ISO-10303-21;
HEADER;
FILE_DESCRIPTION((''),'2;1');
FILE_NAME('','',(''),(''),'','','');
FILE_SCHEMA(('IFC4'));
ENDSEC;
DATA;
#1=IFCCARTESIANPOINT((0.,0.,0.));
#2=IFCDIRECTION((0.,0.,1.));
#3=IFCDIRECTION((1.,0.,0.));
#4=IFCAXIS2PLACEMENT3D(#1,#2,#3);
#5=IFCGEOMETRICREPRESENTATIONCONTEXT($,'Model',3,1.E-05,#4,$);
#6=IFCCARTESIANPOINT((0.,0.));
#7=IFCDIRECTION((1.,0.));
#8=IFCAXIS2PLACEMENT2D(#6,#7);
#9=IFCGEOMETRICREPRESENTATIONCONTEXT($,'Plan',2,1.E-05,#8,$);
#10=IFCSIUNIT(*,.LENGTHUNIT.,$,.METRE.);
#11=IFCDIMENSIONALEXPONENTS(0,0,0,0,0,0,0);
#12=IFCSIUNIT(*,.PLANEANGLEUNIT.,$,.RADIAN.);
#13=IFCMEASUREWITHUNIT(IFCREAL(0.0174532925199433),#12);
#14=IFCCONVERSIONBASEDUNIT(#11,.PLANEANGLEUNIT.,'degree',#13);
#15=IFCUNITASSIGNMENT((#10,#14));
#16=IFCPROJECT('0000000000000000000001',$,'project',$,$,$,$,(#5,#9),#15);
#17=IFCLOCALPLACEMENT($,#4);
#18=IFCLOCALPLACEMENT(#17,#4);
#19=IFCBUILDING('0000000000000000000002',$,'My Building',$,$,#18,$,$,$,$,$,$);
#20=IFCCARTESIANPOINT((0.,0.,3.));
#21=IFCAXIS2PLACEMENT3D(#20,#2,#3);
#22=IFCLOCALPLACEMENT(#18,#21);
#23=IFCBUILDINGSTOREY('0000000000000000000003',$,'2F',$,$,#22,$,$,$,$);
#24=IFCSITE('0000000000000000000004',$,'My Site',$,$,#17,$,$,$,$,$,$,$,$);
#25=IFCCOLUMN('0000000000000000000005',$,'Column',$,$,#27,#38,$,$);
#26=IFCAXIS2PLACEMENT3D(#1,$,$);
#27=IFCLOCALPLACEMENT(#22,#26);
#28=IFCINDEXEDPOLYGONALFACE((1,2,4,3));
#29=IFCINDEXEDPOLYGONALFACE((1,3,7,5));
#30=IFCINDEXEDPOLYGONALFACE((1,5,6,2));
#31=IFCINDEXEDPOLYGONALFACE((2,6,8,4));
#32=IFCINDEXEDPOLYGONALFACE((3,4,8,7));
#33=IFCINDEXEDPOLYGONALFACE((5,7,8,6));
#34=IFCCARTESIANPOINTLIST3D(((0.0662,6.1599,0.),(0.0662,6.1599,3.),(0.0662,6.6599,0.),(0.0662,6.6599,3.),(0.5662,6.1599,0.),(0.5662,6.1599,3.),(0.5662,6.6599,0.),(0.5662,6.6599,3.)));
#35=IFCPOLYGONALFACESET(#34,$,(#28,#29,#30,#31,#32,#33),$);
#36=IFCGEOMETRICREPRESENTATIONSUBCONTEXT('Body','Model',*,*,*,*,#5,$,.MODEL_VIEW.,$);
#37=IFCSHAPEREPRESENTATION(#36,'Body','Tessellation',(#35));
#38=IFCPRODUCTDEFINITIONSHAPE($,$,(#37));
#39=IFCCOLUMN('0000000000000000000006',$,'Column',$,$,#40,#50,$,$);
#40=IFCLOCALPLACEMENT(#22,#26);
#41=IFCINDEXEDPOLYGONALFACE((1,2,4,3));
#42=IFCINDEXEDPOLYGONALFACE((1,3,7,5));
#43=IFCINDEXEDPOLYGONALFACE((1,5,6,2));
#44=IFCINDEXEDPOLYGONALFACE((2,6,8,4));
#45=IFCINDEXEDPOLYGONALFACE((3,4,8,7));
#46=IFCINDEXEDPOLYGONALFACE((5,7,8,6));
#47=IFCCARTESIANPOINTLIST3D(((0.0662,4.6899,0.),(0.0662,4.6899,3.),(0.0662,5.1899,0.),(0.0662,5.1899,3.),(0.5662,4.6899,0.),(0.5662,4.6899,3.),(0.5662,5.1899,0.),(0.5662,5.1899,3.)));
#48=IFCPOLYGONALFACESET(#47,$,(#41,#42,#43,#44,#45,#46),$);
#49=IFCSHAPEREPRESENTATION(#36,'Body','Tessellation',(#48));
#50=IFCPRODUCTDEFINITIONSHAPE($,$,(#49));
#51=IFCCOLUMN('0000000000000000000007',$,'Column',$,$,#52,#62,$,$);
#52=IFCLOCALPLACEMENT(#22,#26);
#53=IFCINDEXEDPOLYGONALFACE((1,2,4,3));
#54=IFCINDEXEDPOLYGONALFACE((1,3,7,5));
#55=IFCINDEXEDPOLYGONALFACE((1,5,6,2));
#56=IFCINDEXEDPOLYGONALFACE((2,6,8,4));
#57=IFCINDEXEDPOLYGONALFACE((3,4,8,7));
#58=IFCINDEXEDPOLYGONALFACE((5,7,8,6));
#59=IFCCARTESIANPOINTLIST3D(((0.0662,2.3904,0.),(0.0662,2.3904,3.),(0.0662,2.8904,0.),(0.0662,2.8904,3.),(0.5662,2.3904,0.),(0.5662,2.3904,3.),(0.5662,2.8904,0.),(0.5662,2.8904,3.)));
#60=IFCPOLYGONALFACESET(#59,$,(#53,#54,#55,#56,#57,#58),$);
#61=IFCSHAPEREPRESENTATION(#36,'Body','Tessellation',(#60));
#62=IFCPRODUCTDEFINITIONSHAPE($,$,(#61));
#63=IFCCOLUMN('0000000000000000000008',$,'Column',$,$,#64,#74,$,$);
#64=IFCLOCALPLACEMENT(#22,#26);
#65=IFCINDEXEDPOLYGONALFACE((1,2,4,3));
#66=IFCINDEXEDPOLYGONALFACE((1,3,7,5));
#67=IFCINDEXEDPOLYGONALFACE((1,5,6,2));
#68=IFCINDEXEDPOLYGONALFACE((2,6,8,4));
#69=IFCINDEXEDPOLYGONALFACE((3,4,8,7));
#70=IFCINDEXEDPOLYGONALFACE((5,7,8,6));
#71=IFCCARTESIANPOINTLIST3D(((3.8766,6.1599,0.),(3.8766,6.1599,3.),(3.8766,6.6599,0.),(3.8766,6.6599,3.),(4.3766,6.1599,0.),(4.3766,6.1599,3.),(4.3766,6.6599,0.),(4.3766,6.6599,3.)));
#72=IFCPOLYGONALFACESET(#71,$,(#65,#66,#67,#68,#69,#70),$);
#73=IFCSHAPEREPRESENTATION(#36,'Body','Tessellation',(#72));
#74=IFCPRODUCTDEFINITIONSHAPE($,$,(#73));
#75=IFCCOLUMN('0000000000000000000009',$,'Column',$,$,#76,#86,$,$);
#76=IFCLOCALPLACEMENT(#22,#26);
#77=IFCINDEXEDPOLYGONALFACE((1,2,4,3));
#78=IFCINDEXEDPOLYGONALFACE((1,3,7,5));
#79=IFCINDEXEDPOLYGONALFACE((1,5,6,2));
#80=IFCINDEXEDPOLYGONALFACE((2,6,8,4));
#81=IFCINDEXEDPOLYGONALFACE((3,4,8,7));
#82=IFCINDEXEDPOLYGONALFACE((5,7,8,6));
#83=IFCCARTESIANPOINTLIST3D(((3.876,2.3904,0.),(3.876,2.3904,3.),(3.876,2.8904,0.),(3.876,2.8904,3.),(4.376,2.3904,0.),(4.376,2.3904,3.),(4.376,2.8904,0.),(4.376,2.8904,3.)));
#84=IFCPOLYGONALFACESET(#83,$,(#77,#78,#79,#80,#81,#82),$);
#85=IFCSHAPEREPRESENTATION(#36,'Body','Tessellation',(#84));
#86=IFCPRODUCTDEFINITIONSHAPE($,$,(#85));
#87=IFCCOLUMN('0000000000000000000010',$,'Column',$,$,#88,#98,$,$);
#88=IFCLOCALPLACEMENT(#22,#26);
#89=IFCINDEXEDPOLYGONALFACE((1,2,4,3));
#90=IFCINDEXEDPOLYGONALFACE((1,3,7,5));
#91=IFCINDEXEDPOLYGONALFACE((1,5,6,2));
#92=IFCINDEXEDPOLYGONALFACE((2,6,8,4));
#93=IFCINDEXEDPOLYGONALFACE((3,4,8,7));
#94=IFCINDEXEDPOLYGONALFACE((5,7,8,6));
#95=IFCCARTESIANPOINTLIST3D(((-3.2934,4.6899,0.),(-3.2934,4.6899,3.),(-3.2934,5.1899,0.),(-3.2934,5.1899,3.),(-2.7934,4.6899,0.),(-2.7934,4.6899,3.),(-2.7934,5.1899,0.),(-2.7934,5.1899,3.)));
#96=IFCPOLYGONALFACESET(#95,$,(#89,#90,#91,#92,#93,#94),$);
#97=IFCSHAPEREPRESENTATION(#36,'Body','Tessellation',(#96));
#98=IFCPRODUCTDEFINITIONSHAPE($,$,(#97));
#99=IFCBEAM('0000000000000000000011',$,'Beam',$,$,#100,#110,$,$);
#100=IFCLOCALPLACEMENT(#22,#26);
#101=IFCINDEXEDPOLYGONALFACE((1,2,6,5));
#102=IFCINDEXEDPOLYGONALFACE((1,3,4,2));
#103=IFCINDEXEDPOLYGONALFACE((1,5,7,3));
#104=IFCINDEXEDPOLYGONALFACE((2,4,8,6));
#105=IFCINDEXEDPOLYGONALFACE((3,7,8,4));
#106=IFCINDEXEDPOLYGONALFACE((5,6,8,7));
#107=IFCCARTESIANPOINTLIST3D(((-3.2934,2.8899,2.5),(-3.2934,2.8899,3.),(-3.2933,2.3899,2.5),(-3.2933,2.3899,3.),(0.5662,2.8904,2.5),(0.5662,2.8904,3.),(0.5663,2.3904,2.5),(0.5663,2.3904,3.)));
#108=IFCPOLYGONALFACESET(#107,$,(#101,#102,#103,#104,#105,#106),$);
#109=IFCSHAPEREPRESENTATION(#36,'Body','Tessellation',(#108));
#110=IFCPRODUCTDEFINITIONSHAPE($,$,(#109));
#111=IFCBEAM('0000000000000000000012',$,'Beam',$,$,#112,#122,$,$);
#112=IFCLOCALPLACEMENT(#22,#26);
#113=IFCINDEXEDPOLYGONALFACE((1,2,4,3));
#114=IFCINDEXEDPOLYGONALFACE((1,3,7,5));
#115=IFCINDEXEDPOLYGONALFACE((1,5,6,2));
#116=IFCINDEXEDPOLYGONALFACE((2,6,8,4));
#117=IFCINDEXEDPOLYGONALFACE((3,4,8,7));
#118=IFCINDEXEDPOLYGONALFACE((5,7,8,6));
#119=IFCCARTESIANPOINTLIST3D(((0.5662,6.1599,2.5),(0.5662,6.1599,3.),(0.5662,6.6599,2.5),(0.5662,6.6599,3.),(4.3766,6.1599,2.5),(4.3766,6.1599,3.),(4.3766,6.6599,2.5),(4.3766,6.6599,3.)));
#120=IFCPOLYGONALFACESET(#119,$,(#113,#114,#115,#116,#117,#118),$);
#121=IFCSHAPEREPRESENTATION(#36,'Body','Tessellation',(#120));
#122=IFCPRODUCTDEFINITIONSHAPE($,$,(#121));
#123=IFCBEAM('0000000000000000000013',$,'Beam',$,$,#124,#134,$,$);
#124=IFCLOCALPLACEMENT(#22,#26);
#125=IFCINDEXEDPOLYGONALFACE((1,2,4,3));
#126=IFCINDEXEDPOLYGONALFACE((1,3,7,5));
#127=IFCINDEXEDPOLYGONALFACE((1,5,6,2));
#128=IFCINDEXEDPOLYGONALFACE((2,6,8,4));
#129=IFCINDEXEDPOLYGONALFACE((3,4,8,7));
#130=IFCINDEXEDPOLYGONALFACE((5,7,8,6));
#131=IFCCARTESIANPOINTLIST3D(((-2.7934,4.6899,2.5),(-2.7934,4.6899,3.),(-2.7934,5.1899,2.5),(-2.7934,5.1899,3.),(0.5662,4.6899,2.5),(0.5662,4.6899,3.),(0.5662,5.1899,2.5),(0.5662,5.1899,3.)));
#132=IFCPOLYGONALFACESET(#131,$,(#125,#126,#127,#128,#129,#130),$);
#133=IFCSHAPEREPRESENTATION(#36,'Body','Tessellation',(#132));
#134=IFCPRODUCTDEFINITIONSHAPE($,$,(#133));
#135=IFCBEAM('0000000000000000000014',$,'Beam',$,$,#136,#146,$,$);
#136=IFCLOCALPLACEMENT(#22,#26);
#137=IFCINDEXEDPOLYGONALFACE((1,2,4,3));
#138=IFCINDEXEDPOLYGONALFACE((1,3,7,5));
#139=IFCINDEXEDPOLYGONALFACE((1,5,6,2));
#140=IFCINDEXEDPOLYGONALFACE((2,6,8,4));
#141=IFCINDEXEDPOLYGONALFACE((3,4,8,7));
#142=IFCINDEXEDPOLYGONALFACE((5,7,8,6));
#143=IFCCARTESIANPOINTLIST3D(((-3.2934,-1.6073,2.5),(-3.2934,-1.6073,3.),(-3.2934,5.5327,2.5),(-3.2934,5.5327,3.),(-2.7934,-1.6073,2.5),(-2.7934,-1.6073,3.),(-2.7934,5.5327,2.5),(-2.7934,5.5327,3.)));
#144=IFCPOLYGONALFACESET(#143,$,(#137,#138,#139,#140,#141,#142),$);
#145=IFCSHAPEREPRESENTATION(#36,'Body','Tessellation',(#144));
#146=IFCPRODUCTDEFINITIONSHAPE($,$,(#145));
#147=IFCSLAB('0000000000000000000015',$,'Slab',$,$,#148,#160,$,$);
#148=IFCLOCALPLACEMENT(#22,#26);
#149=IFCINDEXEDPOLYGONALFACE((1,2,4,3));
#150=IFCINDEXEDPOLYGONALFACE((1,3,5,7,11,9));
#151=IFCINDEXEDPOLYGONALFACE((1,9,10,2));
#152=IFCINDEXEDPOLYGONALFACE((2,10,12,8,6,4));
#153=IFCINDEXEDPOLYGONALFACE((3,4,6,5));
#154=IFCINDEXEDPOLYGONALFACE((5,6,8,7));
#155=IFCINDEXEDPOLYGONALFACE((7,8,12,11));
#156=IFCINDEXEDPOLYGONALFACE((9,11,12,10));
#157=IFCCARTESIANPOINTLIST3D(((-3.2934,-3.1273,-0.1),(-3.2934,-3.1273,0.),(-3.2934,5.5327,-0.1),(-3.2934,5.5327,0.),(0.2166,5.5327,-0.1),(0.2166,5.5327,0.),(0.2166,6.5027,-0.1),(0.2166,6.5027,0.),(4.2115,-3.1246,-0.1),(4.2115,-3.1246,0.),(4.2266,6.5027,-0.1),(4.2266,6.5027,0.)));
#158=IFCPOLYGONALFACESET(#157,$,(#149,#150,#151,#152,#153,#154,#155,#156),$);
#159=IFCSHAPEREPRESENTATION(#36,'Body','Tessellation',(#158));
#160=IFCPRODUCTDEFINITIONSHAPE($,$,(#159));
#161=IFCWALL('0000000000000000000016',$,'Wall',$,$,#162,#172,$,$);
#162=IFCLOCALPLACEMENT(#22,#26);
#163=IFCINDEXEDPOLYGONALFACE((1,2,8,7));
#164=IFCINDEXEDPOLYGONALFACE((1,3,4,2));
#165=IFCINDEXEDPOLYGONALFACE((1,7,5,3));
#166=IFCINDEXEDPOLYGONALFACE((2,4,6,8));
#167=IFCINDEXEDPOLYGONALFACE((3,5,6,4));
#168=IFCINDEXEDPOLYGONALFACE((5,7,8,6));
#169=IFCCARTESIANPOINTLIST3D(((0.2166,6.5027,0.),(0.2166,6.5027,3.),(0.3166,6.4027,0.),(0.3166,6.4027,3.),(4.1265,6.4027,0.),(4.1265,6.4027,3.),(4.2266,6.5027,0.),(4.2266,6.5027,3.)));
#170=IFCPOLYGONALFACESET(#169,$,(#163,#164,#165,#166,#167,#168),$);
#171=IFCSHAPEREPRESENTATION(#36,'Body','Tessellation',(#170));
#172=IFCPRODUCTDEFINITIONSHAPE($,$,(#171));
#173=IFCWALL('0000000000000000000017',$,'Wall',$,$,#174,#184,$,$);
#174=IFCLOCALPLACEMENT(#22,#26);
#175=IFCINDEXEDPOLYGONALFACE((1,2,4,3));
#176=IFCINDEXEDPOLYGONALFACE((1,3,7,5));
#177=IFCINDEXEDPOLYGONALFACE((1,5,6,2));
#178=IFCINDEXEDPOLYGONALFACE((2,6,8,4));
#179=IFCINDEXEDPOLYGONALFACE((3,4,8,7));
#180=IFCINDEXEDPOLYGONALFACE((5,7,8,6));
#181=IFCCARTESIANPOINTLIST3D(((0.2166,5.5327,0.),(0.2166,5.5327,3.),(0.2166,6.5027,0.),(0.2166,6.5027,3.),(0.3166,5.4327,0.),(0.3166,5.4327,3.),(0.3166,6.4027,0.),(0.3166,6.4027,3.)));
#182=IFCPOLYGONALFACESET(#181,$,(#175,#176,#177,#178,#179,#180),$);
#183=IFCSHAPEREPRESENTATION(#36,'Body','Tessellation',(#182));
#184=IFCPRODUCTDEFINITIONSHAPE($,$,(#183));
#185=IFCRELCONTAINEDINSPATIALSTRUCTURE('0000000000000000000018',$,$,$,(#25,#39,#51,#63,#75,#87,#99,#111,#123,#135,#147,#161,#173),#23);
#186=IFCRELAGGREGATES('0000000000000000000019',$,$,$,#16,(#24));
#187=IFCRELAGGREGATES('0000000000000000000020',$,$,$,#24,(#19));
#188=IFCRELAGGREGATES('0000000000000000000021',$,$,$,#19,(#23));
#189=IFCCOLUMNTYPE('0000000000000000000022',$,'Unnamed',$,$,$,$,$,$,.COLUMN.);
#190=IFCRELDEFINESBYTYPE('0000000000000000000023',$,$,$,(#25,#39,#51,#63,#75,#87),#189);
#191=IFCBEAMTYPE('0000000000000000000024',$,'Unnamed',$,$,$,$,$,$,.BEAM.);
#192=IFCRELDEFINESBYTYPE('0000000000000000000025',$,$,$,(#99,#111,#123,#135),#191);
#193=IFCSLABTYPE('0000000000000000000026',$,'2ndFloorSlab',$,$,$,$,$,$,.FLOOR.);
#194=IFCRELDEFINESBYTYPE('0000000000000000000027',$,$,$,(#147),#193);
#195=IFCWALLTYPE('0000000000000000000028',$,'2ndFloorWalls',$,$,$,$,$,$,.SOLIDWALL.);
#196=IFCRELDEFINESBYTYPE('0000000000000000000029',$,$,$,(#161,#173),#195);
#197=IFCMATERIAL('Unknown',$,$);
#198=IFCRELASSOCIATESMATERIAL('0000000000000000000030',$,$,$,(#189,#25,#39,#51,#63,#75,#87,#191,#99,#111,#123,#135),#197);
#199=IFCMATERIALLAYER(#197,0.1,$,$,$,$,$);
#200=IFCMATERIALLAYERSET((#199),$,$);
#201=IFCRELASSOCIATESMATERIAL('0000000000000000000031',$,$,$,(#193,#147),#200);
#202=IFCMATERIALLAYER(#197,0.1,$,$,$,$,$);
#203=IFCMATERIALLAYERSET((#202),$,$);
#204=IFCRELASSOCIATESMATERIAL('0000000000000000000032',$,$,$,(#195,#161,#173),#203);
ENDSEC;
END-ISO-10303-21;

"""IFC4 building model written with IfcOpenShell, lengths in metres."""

from ifc_helpers import new_model, entity, si_unit, converted_unit, frame, origin_with_axes, origin_2d_with_axis, place, context, subcontext, project, spatial, line, indexed_curve, rectangle, outline, extrude, material, layer, layer_set, layer_usage, material_profile, profile_set, profile_usage, type_object, element, save


model = new_model("IFC4")

# Units and contexts
model_context = context("Model", 3, precision=1e-05, world=origin_with_axes())
plan_context = context("Plan", 2, precision=1e-05, world=origin_2d_with_axis())
body_context_1 = subcontext(model_context, "Body", "Model", "MODEL_VIEW")
ifc_project = project(units=[si_unit("LENGTHUNIT", "METRE"), converted_unit("PLANEANGLEUNIT", "degree", entity("IfcReal", 0.0174532925199433), si_unit("PLANEANGLEUNIT", "RADIAN"), dimensions=[0, 0, 0, 0, 0, 0, 0])], contexts=[model_context, plan_context])

# Site, building, storey
site_placement = place(None, origin_with_axes())
site = spatial("IfcSite", under=ifc_project, at=site_placement, Name="My Site")
building_placement = place(site_placement, origin_with_axes())
building = spatial("IfcBuilding", under=site, at=building_placement, Name="My Building")
storey_placement = place(building_placement, frame((0.0, 0.0, 3.0), z_axis=(0.0, 0.0, 1.0), x_axis=(1.0, 0.0, 0.0)))
storey = spatial("IfcBuildingStorey", under=building, at=storey_placement, Name="2F")

# Columns
ifc_material = material(Name="Unknown")
ifc_material_profile_1 = material_profile(ifc_material, rectangle(XDim=0.5, YDim=0.5))
ifc_profile_set_1 = profile_set([ifc_material_profile_1])
ifc_profile_usage_1 = profile_usage(ifc_profile_set_1, cardinal=3)
column_type = type_object("IfcColumnType", Name="Unnamed", PredefinedType="COLUMN", material=ifc_profile_set_1)
column_1_placement = place(storey_placement, frame((0.0662, 6.1599, 0.0), z_axis=(0.0, 0.0, 1.0), x_axis=(1.0, 0.0, 0.0)))
element("IfcColumn", 1, at=column_1_placement, inside=storey, type_object=column_type, material=ifc_profile_usage_1, Name="Column", context=body_context_1, shape_type="SweptSolid", body=[
    extrude(rectangle(XDim=0.5, YDim=0.5), frame((0.25, 0.25, 0.0), z_axis=(0.0, 0.0, 1.0), x_axis=(1.0, 0.0, 0.0)), (0.0, 0.0, 1.0), 3.0),
])
ifc_profile_usage_2 = profile_usage(ifc_profile_set_1, cardinal=3)
column_2_placement = place(storey_placement, frame((0.0662, 4.6899, 0.0), z_axis=(0.0, 0.0, 1.0), x_axis=(1.0, 0.0, 0.0)))
element("IfcColumn", 2, at=column_2_placement, inside=storey, type_object=column_type, material=ifc_profile_usage_2, Name="Column", context=body_context_1, shape_type="SweptSolid", body=[
    extrude(rectangle(XDim=0.5, YDim=0.5), frame((0.25, 0.25, 0.0), z_axis=(0.0, 0.0, 1.0), x_axis=(1.0, 0.0, 0.0)), (0.0, 0.0, 1.0), 3.0),
])
ifc_profile_usage_3 = profile_usage(ifc_profile_set_1, cardinal=7)
column_3_placement = place(storey_placement, frame((0.5662, 2.8904, 0.0), z_axis=(0.0, 0.0, 1.0), x_axis=(1.0, 0.0, 0.0)))
element("IfcColumn", 3, at=column_3_placement, inside=storey, type_object=column_type, material=ifc_profile_usage_3, Name="Column", context=body_context_1, shape_type="SweptSolid", body=[
    extrude(rectangle(XDim=0.5, YDim=0.5), frame((-0.25, -0.25, 0.0), z_axis=(0.0, 0.0, 1.0), x_axis=(1.0, 0.0, 0.0)), (0.0, 0.0, 1.0), 3.0),
])
ifc_profile_usage_4 = profile_usage(ifc_profile_set_1, cardinal=7)
column_4_placement = place(storey_placement, frame((4.3766, 6.6599, 0.0), z_axis=(0.0, 0.0, 1.0), x_axis=(1.0, 0.0, 0.0)))
element("IfcColumn", 4, at=column_4_placement, inside=storey, type_object=column_type, material=ifc_profile_usage_4, Name="Column", context=body_context_1, shape_type="SweptSolid", body=[
    extrude(rectangle(XDim=0.5, YDim=0.5), frame((-0.25, -0.25, 0.0), z_axis=(0.0, 0.0, 1.0), x_axis=(1.0, 0.0, 0.0)), (0.0, 0.0, 1.0), 3.0),
])
ifc_profile_usage_5 = profile_usage(ifc_profile_set_1, cardinal=7)
column_5_placement = place(storey_placement, frame((4.376, 2.8904, 0.0), z_axis=(0.0, 0.0, 1.0), x_axis=(1.0, 0.0, 0.0)))
element("IfcColumn", 5, at=column_5_placement, inside=storey, type_object=column_type, material=ifc_profile_usage_5, Name="Column", context=body_context_1, shape_type="SweptSolid", body=[
    extrude(rectangle(XDim=0.5, YDim=0.5), frame((-0.25, -0.25, 0.0), z_axis=(0.0, 0.0, 1.0), x_axis=(1.0, 0.0, 0.0)), (0.0, 0.0, 1.0), 3.0),
])
ifc_profile_usage_6 = profile_usage(ifc_profile_set_1, cardinal=3)
column_6_placement = place(storey_placement, frame((-3.2934, 4.6899, 0.0), z_axis=(0.0, 0.0, 1.0), x_axis=(1.0, 0.0, 0.0)))
element("IfcColumn", 6, at=column_6_placement, inside=storey, type_object=column_type, material=ifc_profile_usage_6, Name="Column", context=body_context_1, shape_type="SweptSolid", body=[
    extrude(rectangle(XDim=0.5, YDim=0.5), frame((0.25, 0.25, 0.0), z_axis=(0.0, 0.0, 1.0), x_axis=(1.0, 0.0, 0.0)), (0.0, 0.0, 1.0), 3.0),
])

# Beams
ifc_material_profile_2 = material_profile(ifc_material, rectangle(XDim=0.5, YDim=0.5))
ifc_profile_set_2 = profile_set([ifc_material_profile_2])
ifc_profile_usage_7 = profile_usage(ifc_profile_set_2, cardinal=9)
beam_type = type_object("IfcBeamType", Name="Unnamed", PredefinedType="BEAM", material=ifc_profile_set_2)
beam_1_placement = place(storey_placement, frame((0.5662, 2.8904, 3.0), z_axis=(-1.0, -0.000134, 0.0), x_axis=(0.000134, -1.0, 0.0)))
element("IfcBeam", 7, at=beam_1_placement, inside=storey, type_object=beam_type, material=ifc_profile_usage_7, Name="Beam", context=body_context_1, shape_type="SweptSolid", body=[
    extrude(rectangle(XDim=0.5, YDim=0.5), frame((0.25, -0.25, 0.0), z_axis=(0.0, 0.0, 1.0), x_axis=(1.0, 0.0, 0.0)), (0.0, 0.0, 1.0), 3.8596),
])
ifc_profile_usage_8 = profile_usage(ifc_profile_set_2, cardinal=9)
beam_2_placement = place(storey_placement, frame((0.5662, 6.1599, 3.0), z_axis=(1.0, 0.0, 0.0), x_axis=(0.0, 1.0, 0.0)))
element("IfcBeam", 8, at=beam_2_placement, inside=storey, type_object=beam_type, material=ifc_profile_usage_8, Name="Beam", context=body_context_1, shape_type="SweptSolid", body=[
    extrude(rectangle(XDim=0.5, YDim=0.5), frame((0.25, -0.25, 0.0), z_axis=(0.0, 0.0, 1.0), x_axis=(1.0, 0.0, 0.0)), (0.0, 0.0, 1.0), 3.8104),
])
ifc_profile_usage_9 = profile_usage(ifc_profile_set_2, cardinal=7)
beam_3_placement = place(storey_placement, frame((-2.7934, 5.1899, 3.0), z_axis=(1.0, 0.0, 0.0), x_axis=(0.0, 1.0, 0.0)))
element("IfcBeam", 9, at=beam_3_placement, inside=storey, type_object=beam_type, material=ifc_profile_usage_9, Name="Beam", context=body_context_1, shape_type="SweptSolid", body=[
    extrude(rectangle(XDim=0.5, YDim=0.5), frame((-0.25, -0.25, 0.0), z_axis=(0.0, 0.0, 1.0), x_axis=(1.0, 0.0, 0.0)), (0.0, 0.0, 1.0), 3.3596),
])
ifc_profile_usage_10 = profile_usage(ifc_profile_set_2, cardinal=9)
beam_4_placement = place(storey_placement, frame((-3.2934, 5.5327, 3.0), z_axis=(0.0, -1.0, 0.0), x_axis=(1.0, 0.0, 0.0)))
element("IfcBeam", 10, at=beam_4_placement, inside=storey, type_object=beam_type, material=ifc_profile_usage_10, Name="Beam", context=body_context_1, shape_type="SweptSolid", body=[
    extrude(rectangle(XDim=0.5, YDim=0.5), frame((0.25, -0.25, 0.0), z_axis=(0.0, 0.0, 1.0), x_axis=(1.0, 0.0, 0.0)), (0.0, 0.0, 1.0), 7.14),
])

# Slab
ifc_layer_1 = layer(ifc_material, 0.1)
ifc_layer_set_1 = layer_set([ifc_layer_1])
ifc_layer_usage_1 = layer_usage(ifc_layer_set_1, "AXIS3", "POSITIVE", -0.1)
slab_type = type_object("IfcSlabType", Name="2ndFloorSlab", PredefinedType="FLOOR", material=ifc_layer_set_1)
slab_placement = place(storey_placement, frame((4.2266, 6.5027, 0.0), z_axis=(0.0, 0.0, 1.0), x_axis=(1.0, 0.0, 0.0)))
element("IfcSlab", 11, at=slab_placement, inside=storey, type_object=slab_type, material=ifc_layer_usage_1, Name="Slab", context=body_context_1, shape_type="SweptSolid", body=[
    extrude(outline(indexed_curve([(0.0, 0.0), (-4.01, 0.0), (-4.01, -0.97), (-7.52, -0.97), (-7.52, -9.63), (-0.0151, -9.6273), (0.0, 0.0)])), frame((0.0, 0.0, -0.1), z_axis=(0.0, 0.0, 1.0), x_axis=(1.0, 0.0, 0.0)), (0.0, 0.0, 1.0), 0.1),
])

# Walls
ifc_layer_2 = layer(ifc_material, 0.1)
ifc_layer_set_2 = layer_set([ifc_layer_2])
ifc_layer_usage_2 = layer_usage(ifc_layer_set_2, "AXIS2", "POSITIVE", 0.0)
wall_type = type_object("IfcWallType", Name="2ndFloorWalls", PredefinedType="SOLIDWALL", material=ifc_layer_set_2)
wall_1_placement = place(storey_placement, frame((4.2266, 6.5027, 0.0), z_axis=(0.0, 0.0, 1.0), x_axis=(-1.0, 0.0, 0.0)))
element("IfcWall", 12, at=wall_1_placement, inside=storey, type_object=wall_type, material=ifc_layer_usage_2, Name="Wall", context=body_context_1, shape_type="SweptSolid", body=[
    extrude(outline(indexed_curve([(0.0, 0.0), (0.1002, 0.1), (3.91, 0.1), (4.01, 0.0)], segments=[line(1, 2, 3, 4, 1)])), origin_with_axes(), (0.0, 0.0, 1.0), 3.0),
])
ifc_layer_usage_3 = layer_usage(ifc_layer_set_2, "AXIS2", "POSITIVE", 0.0)
wall_2_placement = place(storey_placement, frame((0.2166, 6.5027, 0.0), z_axis=(0.0, 0.0, 1.0), x_axis=(0.0, -1.0, 0.0)))
element("IfcWall", 13, at=wall_2_placement, inside=storey, type_object=wall_type, material=ifc_layer_usage_3, Name="Wall", context=body_context_1, shape_type="SweptSolid", body=[
    extrude(outline(indexed_curve([(0.0, 0.0), (0.1, 0.1), (1.07, 0.1), (0.97, 0.0)], segments=[line(1, 2, 3, 4, 1)])), origin_with_axes(), (0.0, 0.0, 1.0), 3.0),
])

save(model, "model.ifc")
